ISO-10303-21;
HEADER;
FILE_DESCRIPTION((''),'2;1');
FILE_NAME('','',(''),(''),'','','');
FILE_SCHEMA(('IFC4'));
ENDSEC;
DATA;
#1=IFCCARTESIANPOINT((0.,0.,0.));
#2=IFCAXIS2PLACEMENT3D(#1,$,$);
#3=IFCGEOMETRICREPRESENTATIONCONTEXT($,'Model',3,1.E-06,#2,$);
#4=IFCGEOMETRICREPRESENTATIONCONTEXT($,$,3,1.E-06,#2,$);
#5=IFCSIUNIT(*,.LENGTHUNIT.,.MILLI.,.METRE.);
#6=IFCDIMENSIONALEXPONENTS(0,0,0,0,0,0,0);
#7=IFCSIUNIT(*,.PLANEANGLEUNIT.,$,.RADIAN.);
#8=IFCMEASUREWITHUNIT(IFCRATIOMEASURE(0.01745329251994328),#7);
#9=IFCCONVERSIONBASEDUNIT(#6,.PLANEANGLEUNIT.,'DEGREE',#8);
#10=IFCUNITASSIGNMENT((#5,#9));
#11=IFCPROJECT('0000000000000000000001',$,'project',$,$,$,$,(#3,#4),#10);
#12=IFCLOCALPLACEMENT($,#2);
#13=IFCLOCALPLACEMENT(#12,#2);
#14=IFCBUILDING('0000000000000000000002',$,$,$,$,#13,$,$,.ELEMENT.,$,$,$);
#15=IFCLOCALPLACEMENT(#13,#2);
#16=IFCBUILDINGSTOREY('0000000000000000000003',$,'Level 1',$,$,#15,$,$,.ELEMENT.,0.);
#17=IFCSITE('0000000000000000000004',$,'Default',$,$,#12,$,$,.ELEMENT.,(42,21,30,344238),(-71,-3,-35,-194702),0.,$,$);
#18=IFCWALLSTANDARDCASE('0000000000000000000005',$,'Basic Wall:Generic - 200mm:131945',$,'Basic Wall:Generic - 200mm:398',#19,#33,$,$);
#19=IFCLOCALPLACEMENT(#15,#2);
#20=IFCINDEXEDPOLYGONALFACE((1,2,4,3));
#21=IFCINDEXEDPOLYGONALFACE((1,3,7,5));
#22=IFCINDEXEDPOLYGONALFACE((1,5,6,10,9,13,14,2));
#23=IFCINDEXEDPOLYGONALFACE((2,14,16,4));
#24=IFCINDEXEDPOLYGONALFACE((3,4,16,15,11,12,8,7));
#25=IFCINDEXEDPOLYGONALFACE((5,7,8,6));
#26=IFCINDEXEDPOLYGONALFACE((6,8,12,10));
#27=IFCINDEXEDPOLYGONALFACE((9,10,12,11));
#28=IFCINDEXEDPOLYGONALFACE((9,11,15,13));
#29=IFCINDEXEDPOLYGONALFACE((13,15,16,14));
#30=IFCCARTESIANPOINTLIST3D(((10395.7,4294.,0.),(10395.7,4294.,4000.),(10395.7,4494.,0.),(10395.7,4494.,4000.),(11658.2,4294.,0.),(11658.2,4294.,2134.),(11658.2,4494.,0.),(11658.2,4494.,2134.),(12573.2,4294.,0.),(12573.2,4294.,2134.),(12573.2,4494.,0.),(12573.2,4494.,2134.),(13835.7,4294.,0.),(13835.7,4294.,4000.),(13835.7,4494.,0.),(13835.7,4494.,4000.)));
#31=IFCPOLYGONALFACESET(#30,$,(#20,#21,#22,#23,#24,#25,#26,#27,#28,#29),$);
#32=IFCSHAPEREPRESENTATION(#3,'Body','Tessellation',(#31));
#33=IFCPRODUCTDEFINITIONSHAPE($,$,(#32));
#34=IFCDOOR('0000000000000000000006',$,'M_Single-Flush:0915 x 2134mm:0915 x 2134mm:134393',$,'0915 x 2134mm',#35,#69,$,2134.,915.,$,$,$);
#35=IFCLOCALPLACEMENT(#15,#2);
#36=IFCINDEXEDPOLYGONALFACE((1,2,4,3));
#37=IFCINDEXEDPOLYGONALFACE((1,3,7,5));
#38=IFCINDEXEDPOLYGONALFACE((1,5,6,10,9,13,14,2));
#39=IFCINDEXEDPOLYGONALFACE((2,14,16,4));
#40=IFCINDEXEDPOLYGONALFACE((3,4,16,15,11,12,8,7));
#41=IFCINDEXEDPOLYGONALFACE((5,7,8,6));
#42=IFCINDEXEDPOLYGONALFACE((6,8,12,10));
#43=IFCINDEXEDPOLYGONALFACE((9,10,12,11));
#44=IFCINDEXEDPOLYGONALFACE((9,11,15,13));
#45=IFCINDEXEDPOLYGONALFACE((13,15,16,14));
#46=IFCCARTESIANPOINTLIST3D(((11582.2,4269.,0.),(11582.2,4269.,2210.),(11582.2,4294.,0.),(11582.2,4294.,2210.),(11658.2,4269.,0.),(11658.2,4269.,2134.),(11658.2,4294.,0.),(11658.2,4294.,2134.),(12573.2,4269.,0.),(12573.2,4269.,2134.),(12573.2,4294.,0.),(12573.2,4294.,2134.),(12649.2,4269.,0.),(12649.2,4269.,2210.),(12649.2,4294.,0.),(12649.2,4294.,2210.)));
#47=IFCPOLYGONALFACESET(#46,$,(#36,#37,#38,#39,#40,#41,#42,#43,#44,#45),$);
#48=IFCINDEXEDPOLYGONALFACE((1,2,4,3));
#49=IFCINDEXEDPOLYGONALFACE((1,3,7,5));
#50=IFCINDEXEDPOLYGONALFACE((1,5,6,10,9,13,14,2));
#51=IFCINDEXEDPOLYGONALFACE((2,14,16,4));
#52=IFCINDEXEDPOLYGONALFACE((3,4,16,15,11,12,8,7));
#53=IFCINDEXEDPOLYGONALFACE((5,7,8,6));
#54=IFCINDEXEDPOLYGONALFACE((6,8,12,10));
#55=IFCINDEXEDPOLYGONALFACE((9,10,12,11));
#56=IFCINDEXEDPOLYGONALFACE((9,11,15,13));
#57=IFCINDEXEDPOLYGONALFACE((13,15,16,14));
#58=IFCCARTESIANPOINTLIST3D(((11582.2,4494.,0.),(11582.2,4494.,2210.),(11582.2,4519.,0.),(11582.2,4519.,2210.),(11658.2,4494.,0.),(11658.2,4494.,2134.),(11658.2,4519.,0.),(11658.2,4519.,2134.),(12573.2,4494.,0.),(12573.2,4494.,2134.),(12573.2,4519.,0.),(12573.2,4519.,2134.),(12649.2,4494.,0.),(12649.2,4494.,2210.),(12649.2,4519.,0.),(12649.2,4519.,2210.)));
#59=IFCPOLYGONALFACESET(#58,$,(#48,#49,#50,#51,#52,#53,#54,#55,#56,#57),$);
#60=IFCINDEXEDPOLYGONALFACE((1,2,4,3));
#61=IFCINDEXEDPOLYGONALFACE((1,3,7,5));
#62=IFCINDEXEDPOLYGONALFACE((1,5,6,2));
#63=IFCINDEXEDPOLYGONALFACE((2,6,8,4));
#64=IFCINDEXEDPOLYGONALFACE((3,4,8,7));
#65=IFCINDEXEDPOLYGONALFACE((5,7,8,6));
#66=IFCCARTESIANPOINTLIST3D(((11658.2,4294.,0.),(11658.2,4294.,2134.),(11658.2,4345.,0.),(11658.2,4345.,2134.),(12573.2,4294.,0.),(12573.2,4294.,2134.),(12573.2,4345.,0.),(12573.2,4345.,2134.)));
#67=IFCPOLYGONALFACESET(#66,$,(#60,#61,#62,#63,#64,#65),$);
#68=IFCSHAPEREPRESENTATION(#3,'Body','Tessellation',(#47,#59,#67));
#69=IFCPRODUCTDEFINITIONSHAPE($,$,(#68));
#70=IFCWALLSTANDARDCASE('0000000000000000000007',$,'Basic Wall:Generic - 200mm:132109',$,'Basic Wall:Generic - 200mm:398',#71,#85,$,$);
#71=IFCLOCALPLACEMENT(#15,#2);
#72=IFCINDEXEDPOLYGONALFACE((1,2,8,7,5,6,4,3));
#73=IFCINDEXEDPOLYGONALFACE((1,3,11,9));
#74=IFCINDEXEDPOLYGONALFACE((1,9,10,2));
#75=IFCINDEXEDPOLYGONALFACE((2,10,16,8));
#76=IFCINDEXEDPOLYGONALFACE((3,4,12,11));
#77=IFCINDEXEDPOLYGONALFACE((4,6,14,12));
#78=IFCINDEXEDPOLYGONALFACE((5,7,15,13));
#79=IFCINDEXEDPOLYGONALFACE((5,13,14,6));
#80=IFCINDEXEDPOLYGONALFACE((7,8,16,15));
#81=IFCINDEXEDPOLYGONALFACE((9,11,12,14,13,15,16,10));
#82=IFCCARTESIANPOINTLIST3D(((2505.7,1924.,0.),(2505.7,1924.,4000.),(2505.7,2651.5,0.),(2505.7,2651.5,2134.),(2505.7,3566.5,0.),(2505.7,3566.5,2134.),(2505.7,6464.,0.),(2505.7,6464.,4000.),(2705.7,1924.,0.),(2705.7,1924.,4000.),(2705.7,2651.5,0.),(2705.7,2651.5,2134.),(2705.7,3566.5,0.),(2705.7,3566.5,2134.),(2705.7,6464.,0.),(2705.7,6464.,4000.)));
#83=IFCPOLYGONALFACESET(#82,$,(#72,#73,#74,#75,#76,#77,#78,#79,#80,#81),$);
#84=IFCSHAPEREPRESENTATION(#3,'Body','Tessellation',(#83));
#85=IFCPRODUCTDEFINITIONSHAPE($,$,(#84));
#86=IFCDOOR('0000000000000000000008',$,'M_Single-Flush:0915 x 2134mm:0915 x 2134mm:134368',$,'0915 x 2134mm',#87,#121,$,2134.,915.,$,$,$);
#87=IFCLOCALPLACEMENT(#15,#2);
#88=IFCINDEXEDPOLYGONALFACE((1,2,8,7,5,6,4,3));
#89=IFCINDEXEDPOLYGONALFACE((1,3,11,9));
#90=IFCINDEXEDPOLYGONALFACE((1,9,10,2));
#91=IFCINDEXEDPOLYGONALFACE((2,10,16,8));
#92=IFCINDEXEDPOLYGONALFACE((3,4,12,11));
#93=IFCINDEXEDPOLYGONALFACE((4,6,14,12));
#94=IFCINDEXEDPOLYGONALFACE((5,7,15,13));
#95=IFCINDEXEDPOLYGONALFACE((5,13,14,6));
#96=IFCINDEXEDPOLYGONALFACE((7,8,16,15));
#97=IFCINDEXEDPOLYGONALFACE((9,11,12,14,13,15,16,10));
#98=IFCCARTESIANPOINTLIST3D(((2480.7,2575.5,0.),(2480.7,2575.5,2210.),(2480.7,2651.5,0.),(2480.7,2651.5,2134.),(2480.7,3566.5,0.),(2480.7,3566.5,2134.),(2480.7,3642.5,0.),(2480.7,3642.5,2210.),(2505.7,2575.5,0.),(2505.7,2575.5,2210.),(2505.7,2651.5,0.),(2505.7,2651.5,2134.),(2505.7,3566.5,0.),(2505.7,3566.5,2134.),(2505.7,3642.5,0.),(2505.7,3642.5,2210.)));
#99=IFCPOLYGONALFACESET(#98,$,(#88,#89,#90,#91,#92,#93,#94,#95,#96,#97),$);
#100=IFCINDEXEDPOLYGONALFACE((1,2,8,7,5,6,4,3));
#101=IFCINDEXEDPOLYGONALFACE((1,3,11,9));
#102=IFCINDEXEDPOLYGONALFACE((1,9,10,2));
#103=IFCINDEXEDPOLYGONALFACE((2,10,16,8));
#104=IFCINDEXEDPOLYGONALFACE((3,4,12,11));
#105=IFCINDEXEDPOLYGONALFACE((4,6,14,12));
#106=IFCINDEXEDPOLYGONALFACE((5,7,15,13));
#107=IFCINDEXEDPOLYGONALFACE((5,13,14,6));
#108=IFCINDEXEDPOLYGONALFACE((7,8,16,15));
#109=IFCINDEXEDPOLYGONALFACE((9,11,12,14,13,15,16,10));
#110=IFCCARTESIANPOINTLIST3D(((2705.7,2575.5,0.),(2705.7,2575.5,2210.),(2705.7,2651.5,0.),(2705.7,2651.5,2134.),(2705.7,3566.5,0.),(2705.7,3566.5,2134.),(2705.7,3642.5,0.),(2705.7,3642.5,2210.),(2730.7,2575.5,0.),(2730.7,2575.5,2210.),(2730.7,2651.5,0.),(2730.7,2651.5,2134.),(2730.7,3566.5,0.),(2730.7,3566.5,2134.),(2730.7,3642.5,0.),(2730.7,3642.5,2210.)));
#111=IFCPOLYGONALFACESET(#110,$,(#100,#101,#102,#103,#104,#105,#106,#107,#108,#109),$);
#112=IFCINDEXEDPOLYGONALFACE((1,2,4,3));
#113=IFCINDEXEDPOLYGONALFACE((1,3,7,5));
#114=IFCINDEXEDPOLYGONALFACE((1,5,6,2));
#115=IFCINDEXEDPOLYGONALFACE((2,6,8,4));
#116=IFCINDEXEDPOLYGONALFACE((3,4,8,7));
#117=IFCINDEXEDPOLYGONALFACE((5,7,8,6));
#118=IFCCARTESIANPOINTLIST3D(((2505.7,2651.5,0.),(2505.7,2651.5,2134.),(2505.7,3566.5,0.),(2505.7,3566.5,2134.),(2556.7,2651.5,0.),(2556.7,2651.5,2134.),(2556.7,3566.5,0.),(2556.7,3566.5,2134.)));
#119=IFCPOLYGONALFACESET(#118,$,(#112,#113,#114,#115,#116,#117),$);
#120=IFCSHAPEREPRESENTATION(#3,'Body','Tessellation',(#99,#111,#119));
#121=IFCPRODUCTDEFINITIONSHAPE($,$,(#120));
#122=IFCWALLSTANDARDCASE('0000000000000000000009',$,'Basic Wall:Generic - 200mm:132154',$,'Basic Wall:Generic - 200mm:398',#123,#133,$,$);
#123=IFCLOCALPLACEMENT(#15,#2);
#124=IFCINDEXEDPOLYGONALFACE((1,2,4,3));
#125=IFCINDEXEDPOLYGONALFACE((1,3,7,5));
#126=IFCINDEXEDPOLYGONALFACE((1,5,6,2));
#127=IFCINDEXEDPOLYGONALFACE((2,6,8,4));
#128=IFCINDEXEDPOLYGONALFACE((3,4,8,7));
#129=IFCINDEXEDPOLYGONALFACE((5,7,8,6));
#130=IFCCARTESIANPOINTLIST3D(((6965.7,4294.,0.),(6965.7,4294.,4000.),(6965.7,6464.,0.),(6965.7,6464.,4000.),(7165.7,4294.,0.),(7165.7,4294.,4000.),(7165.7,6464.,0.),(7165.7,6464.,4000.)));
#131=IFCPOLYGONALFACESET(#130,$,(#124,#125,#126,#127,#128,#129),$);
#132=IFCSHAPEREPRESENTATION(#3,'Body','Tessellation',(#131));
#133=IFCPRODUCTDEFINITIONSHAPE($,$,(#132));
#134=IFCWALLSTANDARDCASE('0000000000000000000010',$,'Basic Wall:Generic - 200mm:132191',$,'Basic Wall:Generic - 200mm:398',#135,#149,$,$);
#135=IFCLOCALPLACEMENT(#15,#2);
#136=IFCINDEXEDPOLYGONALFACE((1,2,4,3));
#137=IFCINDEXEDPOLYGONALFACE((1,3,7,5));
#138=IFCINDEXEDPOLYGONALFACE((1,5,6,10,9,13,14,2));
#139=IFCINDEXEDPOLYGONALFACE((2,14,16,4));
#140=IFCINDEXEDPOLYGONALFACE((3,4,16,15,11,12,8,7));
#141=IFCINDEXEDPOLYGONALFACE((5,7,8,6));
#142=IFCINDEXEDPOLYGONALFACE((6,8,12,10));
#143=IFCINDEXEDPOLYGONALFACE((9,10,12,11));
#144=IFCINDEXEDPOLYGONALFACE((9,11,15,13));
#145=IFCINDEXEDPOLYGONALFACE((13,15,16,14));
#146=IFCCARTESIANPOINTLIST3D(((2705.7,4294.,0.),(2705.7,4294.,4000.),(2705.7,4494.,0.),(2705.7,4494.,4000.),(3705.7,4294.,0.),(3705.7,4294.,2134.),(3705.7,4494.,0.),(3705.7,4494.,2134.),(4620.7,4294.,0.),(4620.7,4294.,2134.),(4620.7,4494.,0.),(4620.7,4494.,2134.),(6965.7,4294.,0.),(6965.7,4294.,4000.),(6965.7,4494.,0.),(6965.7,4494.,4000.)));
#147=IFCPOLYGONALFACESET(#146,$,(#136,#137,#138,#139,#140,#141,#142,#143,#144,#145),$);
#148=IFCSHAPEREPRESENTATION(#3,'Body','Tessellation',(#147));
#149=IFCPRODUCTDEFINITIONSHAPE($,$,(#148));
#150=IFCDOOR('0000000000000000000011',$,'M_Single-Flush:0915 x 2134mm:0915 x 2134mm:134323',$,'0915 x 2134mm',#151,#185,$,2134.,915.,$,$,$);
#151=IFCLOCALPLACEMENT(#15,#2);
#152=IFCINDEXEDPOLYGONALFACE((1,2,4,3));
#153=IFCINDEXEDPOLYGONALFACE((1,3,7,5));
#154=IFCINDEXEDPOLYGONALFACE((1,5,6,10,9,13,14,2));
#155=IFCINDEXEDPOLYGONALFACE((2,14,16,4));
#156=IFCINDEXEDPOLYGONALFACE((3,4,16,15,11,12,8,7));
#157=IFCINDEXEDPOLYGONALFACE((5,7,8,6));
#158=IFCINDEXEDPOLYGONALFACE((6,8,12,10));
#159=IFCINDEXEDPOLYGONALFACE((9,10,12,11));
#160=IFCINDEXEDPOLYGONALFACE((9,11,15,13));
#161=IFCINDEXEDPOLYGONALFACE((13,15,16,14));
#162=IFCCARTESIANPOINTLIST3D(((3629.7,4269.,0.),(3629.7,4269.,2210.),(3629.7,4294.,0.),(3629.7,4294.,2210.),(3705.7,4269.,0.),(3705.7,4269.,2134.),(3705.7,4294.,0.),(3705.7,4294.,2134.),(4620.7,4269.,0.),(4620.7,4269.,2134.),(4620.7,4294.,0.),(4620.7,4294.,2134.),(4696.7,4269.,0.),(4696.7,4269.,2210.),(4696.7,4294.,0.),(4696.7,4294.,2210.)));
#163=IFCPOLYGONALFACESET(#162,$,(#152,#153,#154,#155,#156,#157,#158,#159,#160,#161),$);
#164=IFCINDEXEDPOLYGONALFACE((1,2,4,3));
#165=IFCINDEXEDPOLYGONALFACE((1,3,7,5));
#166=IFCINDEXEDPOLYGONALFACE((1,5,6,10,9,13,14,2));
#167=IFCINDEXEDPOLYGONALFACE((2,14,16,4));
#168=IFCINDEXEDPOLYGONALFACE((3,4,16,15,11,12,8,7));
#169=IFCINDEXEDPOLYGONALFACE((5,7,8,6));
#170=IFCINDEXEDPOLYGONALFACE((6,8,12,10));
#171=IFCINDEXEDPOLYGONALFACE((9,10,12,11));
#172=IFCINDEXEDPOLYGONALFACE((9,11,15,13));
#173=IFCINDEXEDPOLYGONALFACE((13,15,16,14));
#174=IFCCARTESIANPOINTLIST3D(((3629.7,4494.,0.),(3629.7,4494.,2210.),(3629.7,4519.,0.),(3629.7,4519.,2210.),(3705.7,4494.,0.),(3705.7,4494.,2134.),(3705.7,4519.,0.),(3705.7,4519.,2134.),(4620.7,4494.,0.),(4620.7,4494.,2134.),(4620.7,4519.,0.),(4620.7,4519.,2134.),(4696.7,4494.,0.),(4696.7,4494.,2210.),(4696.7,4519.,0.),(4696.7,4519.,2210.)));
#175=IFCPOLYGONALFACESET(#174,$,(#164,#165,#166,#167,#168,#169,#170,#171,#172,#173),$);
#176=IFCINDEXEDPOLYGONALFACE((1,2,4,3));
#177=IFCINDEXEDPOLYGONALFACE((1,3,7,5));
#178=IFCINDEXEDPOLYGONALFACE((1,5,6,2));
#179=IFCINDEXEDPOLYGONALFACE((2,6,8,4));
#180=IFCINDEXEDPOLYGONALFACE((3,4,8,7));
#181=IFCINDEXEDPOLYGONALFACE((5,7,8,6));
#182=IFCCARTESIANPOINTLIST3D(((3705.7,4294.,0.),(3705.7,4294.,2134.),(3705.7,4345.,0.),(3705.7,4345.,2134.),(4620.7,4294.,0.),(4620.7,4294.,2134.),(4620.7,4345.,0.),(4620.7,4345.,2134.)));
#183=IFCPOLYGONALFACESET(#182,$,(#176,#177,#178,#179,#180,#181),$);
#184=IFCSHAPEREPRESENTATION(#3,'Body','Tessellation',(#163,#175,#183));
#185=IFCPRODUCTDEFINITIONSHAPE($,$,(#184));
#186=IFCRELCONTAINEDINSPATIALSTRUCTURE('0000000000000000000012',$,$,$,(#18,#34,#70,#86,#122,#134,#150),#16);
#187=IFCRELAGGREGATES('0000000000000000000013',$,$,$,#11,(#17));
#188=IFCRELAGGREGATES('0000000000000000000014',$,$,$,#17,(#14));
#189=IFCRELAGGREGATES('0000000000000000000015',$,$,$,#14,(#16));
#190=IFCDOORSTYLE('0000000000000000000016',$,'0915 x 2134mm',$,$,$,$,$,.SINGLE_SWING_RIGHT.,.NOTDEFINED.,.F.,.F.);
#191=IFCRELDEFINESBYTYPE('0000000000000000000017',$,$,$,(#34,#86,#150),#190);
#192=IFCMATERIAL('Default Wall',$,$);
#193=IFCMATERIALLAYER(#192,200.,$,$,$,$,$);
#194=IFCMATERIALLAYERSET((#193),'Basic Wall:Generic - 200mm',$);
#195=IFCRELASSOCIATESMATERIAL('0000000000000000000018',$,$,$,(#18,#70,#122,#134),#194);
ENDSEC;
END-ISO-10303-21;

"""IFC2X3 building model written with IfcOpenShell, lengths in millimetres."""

from ifc_helpers import new_model, entity, si_unit, converted_unit, frame, frame_2d, origin, origin_2d_with_axis, place, context, project, spatial, polyline, rectangle, outline, extrude, source, transform, mapped, material, layer, layer_set, layer_usage, type_object, type_shapes, element, fill, save


model = new_model("IFC2X3")

# Units and contexts
model_context = context("Model", 3, precision=1e-06, world=origin())
context_of_model = context(None, 3, precision=1e-06, world=origin())
ifc_project = project(units=[si_unit("LENGTHUNIT", "METRE", prefix="MILLI"), converted_unit("PLANEANGLEUNIT", "DEGREE", entity("IfcRatioMeasure", 0.01745329251994328), si_unit("PLANEANGLEUNIT", "RADIAN"), dimensions=[0, 0, 0, 0, 0, 0, 0])], contexts=[model_context, context_of_model])

# Site, building, storey
site_placement = place(None, origin())
site = spatial("IfcSite", under=ifc_project, at=site_placement, Name="Default", CompositionType="ELEMENT", RefLatitude=(42, 21, 30, 344238), RefLongitude=(-71, -3, -35, -194702), RefElevation=0.0)
building_placement = place(site_placement, origin())
building = spatial("IfcBuilding", under=site, at=building_placement, CompositionType="ELEMENT")
storey_placement = place(building_placement, origin())
storey = spatial("IfcBuildingStorey", under=building, at=storey_placement, Name="Level 1", CompositionType="ELEMENT", Elevation=0.0)

# Shared definitions
ifc_material_1 = material(Name="Default Wall")
ifc_layer_1 = layer(ifc_material_1, 200.0)
ifc_layer_set_1 = layer_set([ifc_layer_1], Name="Basic Wall:Generic - 200mm")

# Walls, openings, doors
ifc_layer_usage_1 = layer_usage(ifc_layer_set_1, "AXIS2", "NEGATIVE", 100.0)
wall_1_placement = place(storey_placement, frame((10395.7, 4394.0, 0.0)))
wall_1 = element("IfcWallStandardCase", 1, at=wall_1_placement, inside=storey, material=ifc_layer_usage_1, Name="Basic Wall:Generic - 200mm:131945", ObjectType="Basic Wall:Generic - 200mm:398", context=model_context, shape_type="SweptSolid", body=[
    extrude(rectangle(XDim=3440.0, YDim=200.0, at=frame_2d((1720.0, 0.0), x_axis=(-1.0, 0.0))), origin(), (0.0, 0.0, 1.0), 4000.0),
])
opening_1_placement = place(wall_1_placement, frame((2177.5, 100.0, 0.0)))
opening_1 = element("IfcOpeningElement", 2, at=opening_1_placement, cuts=wall_1, ObjectType="Opening", context=model_context, shape_type="SweptSolid", body=[
    extrude(rectangle(XDim=915.0, YDim=2134.0, at=frame_2d((1067.0, 457.5), x_axis=(0.0, 1.0))), frame((0.0, 0.0, 0.0), z_axis=(0.0, -1.0, 0.0), x_axis=(0.0, 0.0, 1.0)), (0.0, 0.0, 1.0), 200.0),
])
door_style_1 = type_object("IfcDoorStyle", Name="0915 x 2134mm", ConstructionType="NOTDEFINED", OperationType="SINGLE_SWING_RIGHT", ParameterTakesPrecedence=False, Sizeable=False)
shared_shape_1 = source(origin(), model_context, "Body", "SweptSolid", [
    extrude(outline(polyline([(-533.5, -1124.0), (533.5, -1124.0), (533.5, 1086.0), (457.5, 1086.0), (457.5, -1048.0), (-457.5, -1048.0), (-457.5, 1086.0), (-533.5, 1086.0), (-533.5, -1124.0)])), frame((457.5, 200.0, 1086.0), z_axis=(0.0, 1.0, 0.0), x_axis=(1.0, 0.0, 0.0)), (0.0, 0.0, 1.0), 25.0),
    extrude(outline(polyline([(-1124.0, -533.5), (1086.0, -533.5), (1086.0, -457.5), (-1048.0, -457.5), (-1048.0, 457.5), (1086.0, 457.5), (1086.0, 533.5), (-1124.0, 533.5), (-1124.0, -533.5)])), frame((457.5, -25.0, 1086.0), z_axis=(0.0, 1.0, 0.0), x_axis=(0.0, 0.0, -1.0)), (0.0, 0.0, 1.0), 25.0),
    extrude(rectangle(XDim=51.0, YDim=915.0, at=origin_2d_with_axis()), frame((457.5, 174.5, 0.0), z_axis=(0.0, 0.0, 1.0), x_axis=(0.0, 1.0, 0.0)), (0.0, 0.0, 1.0), 2134.0),
])
type_shapes(door_style_1, [shared_shape_1])
door_1_placement = place(opening_1_placement, frame((0.0, 0.0, 0.0), z_axis=(0.0, 0.0, 1.0), x_axis=(-1.0, 0.0, 0.0)))
door_1 = element("IfcDoor", 3, at=door_1_placement, inside=storey, type_object=door_style_1, Name="M_Single-Flush:0915 x 2134mm:0915 x 2134mm:134393", ObjectType="0915 x 2134mm", OverallHeight=2134.0, OverallWidth=915.0, context=model_context, shape_type="MappedRepresentation", body=[
    mapped(shared_shape_1, transform((0.0, 0.0, 0.0), scale=1.0)),
])
fill(opening_1, door_1)
ifc_layer_usage_2 = layer_usage(ifc_layer_set_1, "AXIS2", "NEGATIVE", 100.0)
wall_2_placement = place(storey_placement, frame((2605.7, 6464.0, 0.0), z_axis=(0.0, 0.0, 1.0), x_axis=(0.0, -1.0, 0.0)))
wall_2 = element("IfcWallStandardCase", 4, at=wall_2_placement, inside=storey, material=ifc_layer_usage_2, Name="Basic Wall:Generic - 200mm:132109", ObjectType="Basic Wall:Generic - 200mm:398", context=model_context, shape_type="SweptSolid", body=[
    extrude(rectangle(XDim=4540.0, YDim=200.0, at=frame_2d((2270.0, 0.0), x_axis=(-1.0, 0.0))), origin(), (0.0, 0.0, 1.0), 4000.0),
])
opening_2_placement = place(wall_2_placement, frame((3812.5, 100.0, 0.0)))
opening_2 = element("IfcOpeningElement", 5, at=opening_2_placement, cuts=wall_2, ObjectType="Opening", context=model_context, shape_type="SweptSolid", body=[
    extrude(rectangle(XDim=915.0, YDim=2134.0, at=frame_2d((1067.0, 457.5), x_axis=(0.0, 1.0))), frame((0.0, 0.0, 0.0), z_axis=(0.0, -1.0, 0.0), x_axis=(0.0, 0.0, 1.0)), (0.0, 0.0, 1.0), 200.0),
])
door_2_placement = place(opening_2_placement, frame((0.0, 0.0, 0.0), z_axis=(0.0, 0.0, 1.0), x_axis=(-1.0, 0.0, 0.0)))
door_2 = element("IfcDoor", 6, at=door_2_placement, inside=storey, type_object=door_style_1, Name="M_Single-Flush:0915 x 2134mm:0915 x 2134mm:134368", ObjectType="0915 x 2134mm", OverallHeight=2134.0, OverallWidth=915.0, context=model_context, shape_type="MappedRepresentation", body=[
    mapped(shared_shape_1, transform((0.0, 0.0, 0.0), scale=1.0)),
])
fill(opening_2, door_2)

# Wall
ifc_layer_usage_3 = layer_usage(ifc_layer_set_1, "AXIS2", "NEGATIVE", 100.0)
wall_3_placement = place(storey_placement, frame((7065.7, 6464.0, 0.0), z_axis=(0.0, 0.0, 1.0), x_axis=(0.0, -1.0, 0.0)))
element("IfcWallStandardCase", 7, at=wall_3_placement, inside=storey, material=ifc_layer_usage_3, Name="Basic Wall:Generic - 200mm:132154", ObjectType="Basic Wall:Generic - 200mm:398", context=model_context, shape_type="SweptSolid", body=[
    extrude(rectangle(XDim=2170.0, YDim=200.0, at=frame_2d((1085.0, 0.0), x_axis=(-1.0, 0.0))), origin(), (0.0, 0.0, 1.0), 4000.0),
])

# Wall, opening, door
ifc_layer_usage_4 = layer_usage(ifc_layer_set_1, "AXIS2", "NEGATIVE", 100.0)
wall_4_placement = place(storey_placement, frame((6965.7, 4394.0, 0.0), z_axis=(0.0, 0.0, 1.0), x_axis=(-1.0, 0.0, 0.0)))
wall_4 = element("IfcWallStandardCase", 8, at=wall_4_placement, inside=storey, material=ifc_layer_usage_4, Name="Basic Wall:Generic - 200mm:132191", ObjectType="Basic Wall:Generic - 200mm:398", context=model_context, shape_type="SweptSolid", body=[
    extrude(rectangle(XDim=4260.0, YDim=200.0, at=frame_2d((2130.0, 0.0), x_axis=(-1.0, 0.0))), origin(), (0.0, 0.0, 1.0), 4000.0),
])
opening_3_placement = place(wall_4_placement, frame((2345.0, -100.0, 0.0)))
opening_3 = element("IfcOpeningElement", 9, at=opening_3_placement, cuts=wall_4, ObjectType="Opening", context=model_context, shape_type="SweptSolid", body=[
    extrude(rectangle(XDim=915.0, YDim=2134.0, at=frame_2d((1067.0, 457.5), x_axis=(0.0, 1.0))), frame((0.0, 0.0, 0.0), z_axis=(0.0, 1.0, 0.0), x_axis=(0.0, 0.0, 1.0)), (0.0, 0.0, 1.0), 200.0),
])
door_3_placement = place(opening_3_placement, origin())
door_3 = element("IfcDoor", 10, at=door_3_placement, inside=storey, type_object=door_style_1, Name="M_Single-Flush:0915 x 2134mm:0915 x 2134mm:134323", ObjectType="0915 x 2134mm", OverallHeight=2134.0, OverallWidth=915.0, context=model_context, shape_type="MappedRepresentation", body=[
    mapped(shared_shape_1, transform((0.0, 0.0, 0.0), scale=1.0)),
])
fill(opening_3, door_3)

save(model, "model.ifc")
